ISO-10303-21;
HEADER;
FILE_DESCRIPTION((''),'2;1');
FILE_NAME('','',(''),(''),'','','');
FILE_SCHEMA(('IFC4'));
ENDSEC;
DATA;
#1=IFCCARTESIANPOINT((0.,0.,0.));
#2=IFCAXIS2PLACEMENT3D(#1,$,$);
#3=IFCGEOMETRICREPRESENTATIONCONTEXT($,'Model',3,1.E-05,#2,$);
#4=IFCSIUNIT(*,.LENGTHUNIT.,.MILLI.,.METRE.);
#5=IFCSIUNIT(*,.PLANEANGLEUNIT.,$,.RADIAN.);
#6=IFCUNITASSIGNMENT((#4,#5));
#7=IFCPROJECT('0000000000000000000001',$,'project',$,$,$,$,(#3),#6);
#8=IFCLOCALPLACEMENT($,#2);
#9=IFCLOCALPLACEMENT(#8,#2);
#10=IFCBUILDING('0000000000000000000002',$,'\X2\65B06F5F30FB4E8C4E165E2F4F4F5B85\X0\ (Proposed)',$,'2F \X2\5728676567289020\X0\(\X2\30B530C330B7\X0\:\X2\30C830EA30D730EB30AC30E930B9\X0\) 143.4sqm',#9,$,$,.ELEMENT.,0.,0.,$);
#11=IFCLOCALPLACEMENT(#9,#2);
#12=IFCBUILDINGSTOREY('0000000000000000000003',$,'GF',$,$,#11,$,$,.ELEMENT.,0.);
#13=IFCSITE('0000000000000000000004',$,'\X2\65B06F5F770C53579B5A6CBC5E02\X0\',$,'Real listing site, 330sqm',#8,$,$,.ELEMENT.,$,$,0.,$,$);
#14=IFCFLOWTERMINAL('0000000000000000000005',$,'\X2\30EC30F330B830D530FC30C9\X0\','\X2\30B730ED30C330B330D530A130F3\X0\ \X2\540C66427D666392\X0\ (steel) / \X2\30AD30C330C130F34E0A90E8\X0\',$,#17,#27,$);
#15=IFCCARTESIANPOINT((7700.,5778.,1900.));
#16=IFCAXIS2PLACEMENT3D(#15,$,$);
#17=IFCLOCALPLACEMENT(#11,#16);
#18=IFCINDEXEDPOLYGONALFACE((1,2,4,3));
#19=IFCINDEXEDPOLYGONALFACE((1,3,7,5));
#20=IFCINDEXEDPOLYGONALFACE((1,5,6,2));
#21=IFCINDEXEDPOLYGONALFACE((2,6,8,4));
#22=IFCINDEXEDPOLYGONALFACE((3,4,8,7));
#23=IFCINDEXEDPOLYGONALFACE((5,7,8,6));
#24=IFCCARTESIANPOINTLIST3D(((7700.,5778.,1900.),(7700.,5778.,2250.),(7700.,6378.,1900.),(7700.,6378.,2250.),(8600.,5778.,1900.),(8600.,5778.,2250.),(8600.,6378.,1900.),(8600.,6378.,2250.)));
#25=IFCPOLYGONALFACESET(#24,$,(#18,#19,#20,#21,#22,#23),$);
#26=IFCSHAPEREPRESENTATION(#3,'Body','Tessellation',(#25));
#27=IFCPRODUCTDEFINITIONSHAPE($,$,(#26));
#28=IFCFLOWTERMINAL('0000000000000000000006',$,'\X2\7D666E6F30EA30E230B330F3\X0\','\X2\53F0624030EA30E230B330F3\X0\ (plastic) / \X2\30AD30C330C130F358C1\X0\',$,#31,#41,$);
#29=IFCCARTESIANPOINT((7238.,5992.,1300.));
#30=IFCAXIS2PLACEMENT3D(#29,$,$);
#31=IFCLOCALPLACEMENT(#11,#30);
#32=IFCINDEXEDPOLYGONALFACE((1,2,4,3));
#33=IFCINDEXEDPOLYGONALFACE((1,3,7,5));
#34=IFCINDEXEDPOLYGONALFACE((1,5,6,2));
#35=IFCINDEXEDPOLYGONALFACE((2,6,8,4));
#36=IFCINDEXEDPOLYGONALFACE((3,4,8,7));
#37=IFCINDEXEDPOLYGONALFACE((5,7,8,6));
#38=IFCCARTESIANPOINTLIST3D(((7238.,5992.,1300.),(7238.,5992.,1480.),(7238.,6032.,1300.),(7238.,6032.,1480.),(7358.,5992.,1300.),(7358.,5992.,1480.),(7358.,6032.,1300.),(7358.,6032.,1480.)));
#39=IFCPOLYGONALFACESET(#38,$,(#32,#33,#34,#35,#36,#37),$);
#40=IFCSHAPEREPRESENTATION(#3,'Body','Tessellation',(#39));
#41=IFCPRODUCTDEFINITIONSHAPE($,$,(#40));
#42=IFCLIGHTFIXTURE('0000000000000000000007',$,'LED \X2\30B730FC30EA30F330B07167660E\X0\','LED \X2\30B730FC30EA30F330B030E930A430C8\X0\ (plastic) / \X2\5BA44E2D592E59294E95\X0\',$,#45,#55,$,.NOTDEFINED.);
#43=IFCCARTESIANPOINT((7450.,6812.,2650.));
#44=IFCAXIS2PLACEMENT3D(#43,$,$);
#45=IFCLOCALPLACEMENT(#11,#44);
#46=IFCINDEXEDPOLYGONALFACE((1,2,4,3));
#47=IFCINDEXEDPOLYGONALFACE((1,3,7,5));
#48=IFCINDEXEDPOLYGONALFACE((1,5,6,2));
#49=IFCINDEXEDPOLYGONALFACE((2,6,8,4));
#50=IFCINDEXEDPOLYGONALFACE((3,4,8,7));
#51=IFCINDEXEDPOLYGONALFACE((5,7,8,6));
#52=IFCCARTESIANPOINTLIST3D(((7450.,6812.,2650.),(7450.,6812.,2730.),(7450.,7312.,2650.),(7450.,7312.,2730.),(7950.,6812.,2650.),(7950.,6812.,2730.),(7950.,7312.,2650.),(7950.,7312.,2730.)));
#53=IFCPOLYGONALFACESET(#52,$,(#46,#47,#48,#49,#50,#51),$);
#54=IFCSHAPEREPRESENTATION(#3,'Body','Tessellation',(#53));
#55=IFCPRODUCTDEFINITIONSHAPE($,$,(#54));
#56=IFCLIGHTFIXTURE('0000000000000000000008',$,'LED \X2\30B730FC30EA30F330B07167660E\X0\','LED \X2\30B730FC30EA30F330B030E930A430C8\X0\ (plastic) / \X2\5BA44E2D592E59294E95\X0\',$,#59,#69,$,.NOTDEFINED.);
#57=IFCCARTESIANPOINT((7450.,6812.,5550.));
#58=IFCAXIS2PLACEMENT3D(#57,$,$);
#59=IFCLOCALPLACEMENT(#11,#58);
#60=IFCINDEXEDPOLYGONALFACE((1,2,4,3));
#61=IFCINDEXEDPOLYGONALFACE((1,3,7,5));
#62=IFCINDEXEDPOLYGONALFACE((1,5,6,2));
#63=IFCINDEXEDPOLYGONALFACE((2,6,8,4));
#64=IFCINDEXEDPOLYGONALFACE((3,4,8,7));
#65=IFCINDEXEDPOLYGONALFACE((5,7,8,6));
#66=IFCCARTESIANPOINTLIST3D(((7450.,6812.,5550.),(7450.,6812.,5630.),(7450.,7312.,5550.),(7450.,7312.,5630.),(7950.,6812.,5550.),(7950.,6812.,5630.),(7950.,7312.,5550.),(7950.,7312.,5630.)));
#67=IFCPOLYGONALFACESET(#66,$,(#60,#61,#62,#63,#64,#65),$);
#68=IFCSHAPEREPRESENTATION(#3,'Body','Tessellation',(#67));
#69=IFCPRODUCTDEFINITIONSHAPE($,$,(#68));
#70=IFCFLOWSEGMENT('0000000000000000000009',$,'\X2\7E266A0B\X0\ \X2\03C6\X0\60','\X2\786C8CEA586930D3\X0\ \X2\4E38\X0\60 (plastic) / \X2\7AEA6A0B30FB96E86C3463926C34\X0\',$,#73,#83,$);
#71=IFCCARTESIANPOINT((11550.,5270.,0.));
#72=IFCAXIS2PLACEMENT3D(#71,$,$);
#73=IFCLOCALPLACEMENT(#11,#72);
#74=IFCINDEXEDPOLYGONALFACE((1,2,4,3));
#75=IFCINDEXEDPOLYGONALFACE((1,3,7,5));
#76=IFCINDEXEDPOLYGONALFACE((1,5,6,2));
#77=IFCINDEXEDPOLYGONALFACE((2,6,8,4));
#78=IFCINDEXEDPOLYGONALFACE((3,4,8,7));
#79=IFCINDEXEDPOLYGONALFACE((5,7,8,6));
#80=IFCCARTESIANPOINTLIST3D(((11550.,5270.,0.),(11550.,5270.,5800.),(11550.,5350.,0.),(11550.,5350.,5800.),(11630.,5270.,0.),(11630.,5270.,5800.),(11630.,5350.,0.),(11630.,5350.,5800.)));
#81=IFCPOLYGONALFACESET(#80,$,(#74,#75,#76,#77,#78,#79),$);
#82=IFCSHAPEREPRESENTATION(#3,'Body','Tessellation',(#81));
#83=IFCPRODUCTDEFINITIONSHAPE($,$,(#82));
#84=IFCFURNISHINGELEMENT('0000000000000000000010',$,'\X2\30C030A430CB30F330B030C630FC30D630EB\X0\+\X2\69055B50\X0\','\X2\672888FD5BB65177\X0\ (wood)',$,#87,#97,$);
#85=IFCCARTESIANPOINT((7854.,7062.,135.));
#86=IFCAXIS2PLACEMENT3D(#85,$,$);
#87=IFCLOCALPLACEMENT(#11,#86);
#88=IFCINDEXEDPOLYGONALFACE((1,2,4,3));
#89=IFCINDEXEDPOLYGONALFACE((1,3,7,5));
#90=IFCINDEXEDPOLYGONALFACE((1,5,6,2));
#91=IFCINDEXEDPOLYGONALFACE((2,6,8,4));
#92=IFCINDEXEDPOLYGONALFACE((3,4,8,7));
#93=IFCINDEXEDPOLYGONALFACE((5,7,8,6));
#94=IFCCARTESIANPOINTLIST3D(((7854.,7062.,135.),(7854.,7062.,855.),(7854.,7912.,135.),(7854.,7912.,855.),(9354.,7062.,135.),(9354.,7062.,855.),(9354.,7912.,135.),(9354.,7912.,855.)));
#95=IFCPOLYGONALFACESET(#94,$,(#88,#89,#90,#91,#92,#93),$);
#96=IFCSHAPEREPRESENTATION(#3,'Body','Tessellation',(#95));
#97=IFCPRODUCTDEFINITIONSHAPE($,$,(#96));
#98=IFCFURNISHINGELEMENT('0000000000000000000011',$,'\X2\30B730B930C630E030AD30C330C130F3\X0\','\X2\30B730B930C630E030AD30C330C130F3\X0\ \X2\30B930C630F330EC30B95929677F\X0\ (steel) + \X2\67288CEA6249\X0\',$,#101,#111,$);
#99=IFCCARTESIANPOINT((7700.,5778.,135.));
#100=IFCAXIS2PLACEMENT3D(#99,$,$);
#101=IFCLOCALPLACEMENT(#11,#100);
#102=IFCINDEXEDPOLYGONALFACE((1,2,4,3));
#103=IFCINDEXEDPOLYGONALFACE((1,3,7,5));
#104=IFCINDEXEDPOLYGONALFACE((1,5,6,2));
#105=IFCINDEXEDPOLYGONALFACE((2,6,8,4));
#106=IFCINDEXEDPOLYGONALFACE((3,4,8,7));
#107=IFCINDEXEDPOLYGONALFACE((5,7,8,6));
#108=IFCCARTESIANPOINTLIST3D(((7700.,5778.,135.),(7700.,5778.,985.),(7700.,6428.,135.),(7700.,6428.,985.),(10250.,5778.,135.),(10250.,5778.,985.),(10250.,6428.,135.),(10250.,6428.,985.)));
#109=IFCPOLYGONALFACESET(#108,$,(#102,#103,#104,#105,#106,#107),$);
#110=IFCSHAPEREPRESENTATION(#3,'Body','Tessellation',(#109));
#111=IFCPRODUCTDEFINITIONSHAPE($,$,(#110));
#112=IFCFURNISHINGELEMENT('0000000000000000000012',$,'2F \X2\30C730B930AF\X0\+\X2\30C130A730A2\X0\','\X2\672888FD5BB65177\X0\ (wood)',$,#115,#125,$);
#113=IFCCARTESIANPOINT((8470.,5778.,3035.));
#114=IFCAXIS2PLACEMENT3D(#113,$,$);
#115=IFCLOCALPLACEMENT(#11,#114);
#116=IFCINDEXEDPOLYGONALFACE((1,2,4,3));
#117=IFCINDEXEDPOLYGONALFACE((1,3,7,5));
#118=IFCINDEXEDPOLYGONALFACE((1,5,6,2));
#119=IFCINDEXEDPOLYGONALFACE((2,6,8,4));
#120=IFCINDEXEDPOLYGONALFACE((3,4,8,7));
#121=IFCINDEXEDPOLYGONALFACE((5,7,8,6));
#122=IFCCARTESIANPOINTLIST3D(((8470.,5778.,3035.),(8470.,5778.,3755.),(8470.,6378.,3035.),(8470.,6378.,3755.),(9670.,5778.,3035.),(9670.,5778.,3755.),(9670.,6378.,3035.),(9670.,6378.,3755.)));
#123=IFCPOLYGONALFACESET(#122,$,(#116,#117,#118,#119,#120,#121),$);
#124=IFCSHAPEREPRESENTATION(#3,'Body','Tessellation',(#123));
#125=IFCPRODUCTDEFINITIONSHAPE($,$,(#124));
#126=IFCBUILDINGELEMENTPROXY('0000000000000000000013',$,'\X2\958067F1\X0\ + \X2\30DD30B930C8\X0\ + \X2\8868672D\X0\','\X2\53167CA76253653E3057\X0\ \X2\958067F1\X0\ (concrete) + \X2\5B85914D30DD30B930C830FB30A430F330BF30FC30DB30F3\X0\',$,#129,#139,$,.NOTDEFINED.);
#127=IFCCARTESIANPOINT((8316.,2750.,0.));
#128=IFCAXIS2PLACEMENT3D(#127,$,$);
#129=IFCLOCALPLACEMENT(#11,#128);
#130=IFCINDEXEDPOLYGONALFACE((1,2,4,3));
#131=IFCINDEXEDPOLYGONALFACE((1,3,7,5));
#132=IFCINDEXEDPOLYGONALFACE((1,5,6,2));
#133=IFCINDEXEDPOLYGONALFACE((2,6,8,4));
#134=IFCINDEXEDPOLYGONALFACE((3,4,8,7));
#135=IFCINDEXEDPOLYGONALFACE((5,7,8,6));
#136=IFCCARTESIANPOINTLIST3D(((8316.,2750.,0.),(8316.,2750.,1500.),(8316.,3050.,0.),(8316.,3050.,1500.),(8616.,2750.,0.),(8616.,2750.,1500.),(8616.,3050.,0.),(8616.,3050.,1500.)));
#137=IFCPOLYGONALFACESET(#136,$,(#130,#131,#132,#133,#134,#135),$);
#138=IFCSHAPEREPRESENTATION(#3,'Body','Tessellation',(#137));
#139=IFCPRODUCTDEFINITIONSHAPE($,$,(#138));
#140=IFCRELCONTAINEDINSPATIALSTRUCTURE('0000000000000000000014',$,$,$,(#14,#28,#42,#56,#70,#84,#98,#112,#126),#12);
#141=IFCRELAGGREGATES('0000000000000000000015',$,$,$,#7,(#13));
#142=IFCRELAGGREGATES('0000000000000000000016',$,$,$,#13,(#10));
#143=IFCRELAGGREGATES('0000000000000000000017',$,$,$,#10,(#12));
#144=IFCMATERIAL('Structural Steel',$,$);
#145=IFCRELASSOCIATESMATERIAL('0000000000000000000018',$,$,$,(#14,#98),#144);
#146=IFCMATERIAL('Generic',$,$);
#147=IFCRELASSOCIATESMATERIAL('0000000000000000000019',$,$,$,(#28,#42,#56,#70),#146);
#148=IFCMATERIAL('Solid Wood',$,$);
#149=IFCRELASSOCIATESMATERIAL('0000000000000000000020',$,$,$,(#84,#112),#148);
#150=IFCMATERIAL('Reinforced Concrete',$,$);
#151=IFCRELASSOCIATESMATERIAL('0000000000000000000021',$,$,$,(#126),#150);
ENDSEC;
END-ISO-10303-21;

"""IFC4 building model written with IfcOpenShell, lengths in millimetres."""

from ifc_helpers import new_model, si_unit, frame, frame_2d, origin, place, context, project, spatial, rectangle, extrude, material, element, save


model = new_model("IFC4")

# Units and contexts
model_context = context("Model", 3, precision=1e-05, world=origin())
ifc_project = project(units=[si_unit("LENGTHUNIT", "METRE", prefix="MILLI"), si_unit("PLANEANGLEUNIT", "RADIAN")], contexts=[model_context])

# Site, building, storey
site_placement = place(None, origin())
site = spatial("IfcSite", under=ifc_project, at=site_placement, Name="新潟県南魚沼市", ObjectType="Real listing site, 330sqm", CompositionType="ELEMENT", RefElevation=0.0)
building_placement = place(site_placement, origin())
building = spatial("IfcBuilding", under=site, at=building_placement, Name="新潟・二世帯住宅 (Proposed)", ObjectType="2F 在来木造(サッシ:トリプルガラス) 143.4sqm", CompositionType="ELEMENT", ElevationOfRefHeight=0.0, ElevationOfTerrain=0.0)
storey_placement = place(building_placement, origin())
storey = spatial("IfcBuildingStorey", under=building, at=storey_placement, Name="GF", CompositionType="ELEMENT", Elevation=0.0)

# Shared definitions
ifc_material_1 = material(Name="Solid Wood")

# Shared definitions
ifc_material_2 = material(Name="Reinforced Concrete")

# Shared definitions
ifc_material_3 = material(Name="Structural Steel")

# Flow terminals
flow_terminal_1_placement = place(storey_placement, frame((7700.0, 5778.0, 1900.0)))
element("IfcFlowTerminal", 1, at=flow_terminal_1_placement, inside=storey, material=ifc_material_3, Name="レンジフード", Description="シロッコファン 同時給排 (steel) / キッチン上部", context=model_context, shape_type="SweptSolid", body=[
    extrude(rectangle(XDim=900.0, YDim=600.0, at=frame_2d((450.0, 300.0))), frame((7700.0, 5778.0, 1900.0)), (0.0, 0.0, 1.0), 350.0),
])
ifc_material_4 = material(Name="Generic")
flow_terminal_2_placement = place(storey_placement, frame((7238.0, 5992.0, 1300.0)))
element("IfcFlowTerminal", 2, at=flow_terminal_2_placement, inside=storey, material=ifc_material_4, Name="給湯リモコン", Description="台所リモコン (plastic) / キッチン壁", context=model_context, shape_type="SweptSolid", body=[
    extrude(rectangle(XDim=120.0, YDim=40.0, at=frame_2d((60.0, 20.0))), frame((7238.0, 5992.0, 1300.0)), (0.0, 0.0, 1.0), 180.0),
])

# Light fixtures
light_fixture_1_placement = place(storey_placement, frame((7450.0, 6812.0, 2650.0)))
element("IfcLightFixture", 3, at=light_fixture_1_placement, inside=storey, material=ifc_material_4, Name="LED シーリング照明", Description="LED シーリングライト (plastic) / 室中央天井", PredefinedType="NOTDEFINED", context=model_context, shape_type="SweptSolid", body=[
    extrude(rectangle(XDim=500.0, YDim=500.0, at=frame_2d((250.0, 250.0))), frame((7450.0, 6812.0, 2650.0)), (0.0, 0.0, 1.0), 80.0),
])
light_fixture_2_placement = place(storey_placement, frame((7450.0, 6812.0, 5550.0)))
element("IfcLightFixture", 4, at=light_fixture_2_placement, inside=storey, material=ifc_material_4, Name="LED シーリング照明", Description="LED シーリングライト (plastic) / 室中央天井", PredefinedType="NOTDEFINED", context=model_context, shape_type="SweptSolid", body=[
    extrude(rectangle(XDim=500.0, YDim=500.0, at=frame_2d((250.0, 250.0))), frame((7450.0, 6812.0, 5550.0)), (0.0, 0.0, 1.0), 80.0),
])

# Flow segment
flow_segment_placement = place(storey_placement, frame((11550.0, 5270.0, 0.0)))
element("IfcFlowSegment", 5, at=flow_segment_placement, inside=storey, material=ifc_material_4, Name="縦樋 φ60", Description="硬質塩ビ 丸60 (plastic) / 竪樋・雨水排水", context=model_context, shape_type="SweptSolid", body=[
    extrude(rectangle(XDim=80.0, YDim=80.0, at=frame_2d((40.0, 40.0))), frame((11550.0, 5270.0, 0.0)), (0.0, 0.0, 1.0), 5800.0),
])

# Furnishing elements
furnishing_1_placement = place(storey_placement, frame((7854.0, 7062.0, 135.0)))
element("IfcFurnishingElement", 6, at=furnishing_1_placement, inside=storey, material=ifc_material_1, Name="ダイニングテーブル+椅子", Description="木製家具 (wood)", context=model_context, shape_type="SweptSolid", body=[
    extrude(rectangle(XDim=1500.0, YDim=850.0, at=frame_2d((750.0, 425.0))), frame((7854.0, 7062.0, 135.0)), (0.0, 0.0, 1.0), 720.0),
])
furnishing_2_placement = place(storey_placement, frame((7700.0, 5778.0, 135.0)))
element("IfcFurnishingElement", 7, at=furnishing_2_placement, inside=storey, material=ifc_material_3, Name="システムキッチン", Description="システムキッチン ステンレス天板 (steel) + 木質扉", context=model_context, shape_type="SweptSolid", body=[
    extrude(rectangle(XDim=2550.0, YDim=650.0, at=frame_2d((1275.0, 325.0))), frame((7700.0, 5778.0, 135.0)), (0.0, 0.0, 1.0), 850.0),
])
furnishing_3_placement = place(storey_placement, frame((8470.0, 5778.0, 3035.0)))
element("IfcFurnishingElement", 8, at=furnishing_3_placement, inside=storey, material=ifc_material_1, Name="2F デスク+チェア", Description="木製家具 (wood)", context=model_context, shape_type="SweptSolid", body=[
    extrude(rectangle(XDim=1200.0, YDim=600.0, at=frame_2d((600.0, 300.0))), frame((8470.0, 5778.0, 3035.0)), (0.0, 0.0, 1.0), 720.0),
])

# Building element proxy
proxy_placement = place(storey_placement, frame((8316.0, 2750.0, 0.0)))
element("IfcBuildingElementProxy", 9, at=proxy_placement, inside=storey, material=ifc_material_2, Name="門柱 + ポスト + 表札", Description="化粧打放し 門柱 (concrete) + 宅配ポスト・インターホン", PredefinedType="NOTDEFINED", context=model_context, shape_type="SweptSolid", body=[
    extrude(rectangle(XDim=300.0, YDim=300.0, at=frame_2d((150.0, 150.0))), frame((8316.0, 2750.0, 0.0)), (0.0, 0.0, 1.0), 1500.0),
])

save(model, "model.ifc")
